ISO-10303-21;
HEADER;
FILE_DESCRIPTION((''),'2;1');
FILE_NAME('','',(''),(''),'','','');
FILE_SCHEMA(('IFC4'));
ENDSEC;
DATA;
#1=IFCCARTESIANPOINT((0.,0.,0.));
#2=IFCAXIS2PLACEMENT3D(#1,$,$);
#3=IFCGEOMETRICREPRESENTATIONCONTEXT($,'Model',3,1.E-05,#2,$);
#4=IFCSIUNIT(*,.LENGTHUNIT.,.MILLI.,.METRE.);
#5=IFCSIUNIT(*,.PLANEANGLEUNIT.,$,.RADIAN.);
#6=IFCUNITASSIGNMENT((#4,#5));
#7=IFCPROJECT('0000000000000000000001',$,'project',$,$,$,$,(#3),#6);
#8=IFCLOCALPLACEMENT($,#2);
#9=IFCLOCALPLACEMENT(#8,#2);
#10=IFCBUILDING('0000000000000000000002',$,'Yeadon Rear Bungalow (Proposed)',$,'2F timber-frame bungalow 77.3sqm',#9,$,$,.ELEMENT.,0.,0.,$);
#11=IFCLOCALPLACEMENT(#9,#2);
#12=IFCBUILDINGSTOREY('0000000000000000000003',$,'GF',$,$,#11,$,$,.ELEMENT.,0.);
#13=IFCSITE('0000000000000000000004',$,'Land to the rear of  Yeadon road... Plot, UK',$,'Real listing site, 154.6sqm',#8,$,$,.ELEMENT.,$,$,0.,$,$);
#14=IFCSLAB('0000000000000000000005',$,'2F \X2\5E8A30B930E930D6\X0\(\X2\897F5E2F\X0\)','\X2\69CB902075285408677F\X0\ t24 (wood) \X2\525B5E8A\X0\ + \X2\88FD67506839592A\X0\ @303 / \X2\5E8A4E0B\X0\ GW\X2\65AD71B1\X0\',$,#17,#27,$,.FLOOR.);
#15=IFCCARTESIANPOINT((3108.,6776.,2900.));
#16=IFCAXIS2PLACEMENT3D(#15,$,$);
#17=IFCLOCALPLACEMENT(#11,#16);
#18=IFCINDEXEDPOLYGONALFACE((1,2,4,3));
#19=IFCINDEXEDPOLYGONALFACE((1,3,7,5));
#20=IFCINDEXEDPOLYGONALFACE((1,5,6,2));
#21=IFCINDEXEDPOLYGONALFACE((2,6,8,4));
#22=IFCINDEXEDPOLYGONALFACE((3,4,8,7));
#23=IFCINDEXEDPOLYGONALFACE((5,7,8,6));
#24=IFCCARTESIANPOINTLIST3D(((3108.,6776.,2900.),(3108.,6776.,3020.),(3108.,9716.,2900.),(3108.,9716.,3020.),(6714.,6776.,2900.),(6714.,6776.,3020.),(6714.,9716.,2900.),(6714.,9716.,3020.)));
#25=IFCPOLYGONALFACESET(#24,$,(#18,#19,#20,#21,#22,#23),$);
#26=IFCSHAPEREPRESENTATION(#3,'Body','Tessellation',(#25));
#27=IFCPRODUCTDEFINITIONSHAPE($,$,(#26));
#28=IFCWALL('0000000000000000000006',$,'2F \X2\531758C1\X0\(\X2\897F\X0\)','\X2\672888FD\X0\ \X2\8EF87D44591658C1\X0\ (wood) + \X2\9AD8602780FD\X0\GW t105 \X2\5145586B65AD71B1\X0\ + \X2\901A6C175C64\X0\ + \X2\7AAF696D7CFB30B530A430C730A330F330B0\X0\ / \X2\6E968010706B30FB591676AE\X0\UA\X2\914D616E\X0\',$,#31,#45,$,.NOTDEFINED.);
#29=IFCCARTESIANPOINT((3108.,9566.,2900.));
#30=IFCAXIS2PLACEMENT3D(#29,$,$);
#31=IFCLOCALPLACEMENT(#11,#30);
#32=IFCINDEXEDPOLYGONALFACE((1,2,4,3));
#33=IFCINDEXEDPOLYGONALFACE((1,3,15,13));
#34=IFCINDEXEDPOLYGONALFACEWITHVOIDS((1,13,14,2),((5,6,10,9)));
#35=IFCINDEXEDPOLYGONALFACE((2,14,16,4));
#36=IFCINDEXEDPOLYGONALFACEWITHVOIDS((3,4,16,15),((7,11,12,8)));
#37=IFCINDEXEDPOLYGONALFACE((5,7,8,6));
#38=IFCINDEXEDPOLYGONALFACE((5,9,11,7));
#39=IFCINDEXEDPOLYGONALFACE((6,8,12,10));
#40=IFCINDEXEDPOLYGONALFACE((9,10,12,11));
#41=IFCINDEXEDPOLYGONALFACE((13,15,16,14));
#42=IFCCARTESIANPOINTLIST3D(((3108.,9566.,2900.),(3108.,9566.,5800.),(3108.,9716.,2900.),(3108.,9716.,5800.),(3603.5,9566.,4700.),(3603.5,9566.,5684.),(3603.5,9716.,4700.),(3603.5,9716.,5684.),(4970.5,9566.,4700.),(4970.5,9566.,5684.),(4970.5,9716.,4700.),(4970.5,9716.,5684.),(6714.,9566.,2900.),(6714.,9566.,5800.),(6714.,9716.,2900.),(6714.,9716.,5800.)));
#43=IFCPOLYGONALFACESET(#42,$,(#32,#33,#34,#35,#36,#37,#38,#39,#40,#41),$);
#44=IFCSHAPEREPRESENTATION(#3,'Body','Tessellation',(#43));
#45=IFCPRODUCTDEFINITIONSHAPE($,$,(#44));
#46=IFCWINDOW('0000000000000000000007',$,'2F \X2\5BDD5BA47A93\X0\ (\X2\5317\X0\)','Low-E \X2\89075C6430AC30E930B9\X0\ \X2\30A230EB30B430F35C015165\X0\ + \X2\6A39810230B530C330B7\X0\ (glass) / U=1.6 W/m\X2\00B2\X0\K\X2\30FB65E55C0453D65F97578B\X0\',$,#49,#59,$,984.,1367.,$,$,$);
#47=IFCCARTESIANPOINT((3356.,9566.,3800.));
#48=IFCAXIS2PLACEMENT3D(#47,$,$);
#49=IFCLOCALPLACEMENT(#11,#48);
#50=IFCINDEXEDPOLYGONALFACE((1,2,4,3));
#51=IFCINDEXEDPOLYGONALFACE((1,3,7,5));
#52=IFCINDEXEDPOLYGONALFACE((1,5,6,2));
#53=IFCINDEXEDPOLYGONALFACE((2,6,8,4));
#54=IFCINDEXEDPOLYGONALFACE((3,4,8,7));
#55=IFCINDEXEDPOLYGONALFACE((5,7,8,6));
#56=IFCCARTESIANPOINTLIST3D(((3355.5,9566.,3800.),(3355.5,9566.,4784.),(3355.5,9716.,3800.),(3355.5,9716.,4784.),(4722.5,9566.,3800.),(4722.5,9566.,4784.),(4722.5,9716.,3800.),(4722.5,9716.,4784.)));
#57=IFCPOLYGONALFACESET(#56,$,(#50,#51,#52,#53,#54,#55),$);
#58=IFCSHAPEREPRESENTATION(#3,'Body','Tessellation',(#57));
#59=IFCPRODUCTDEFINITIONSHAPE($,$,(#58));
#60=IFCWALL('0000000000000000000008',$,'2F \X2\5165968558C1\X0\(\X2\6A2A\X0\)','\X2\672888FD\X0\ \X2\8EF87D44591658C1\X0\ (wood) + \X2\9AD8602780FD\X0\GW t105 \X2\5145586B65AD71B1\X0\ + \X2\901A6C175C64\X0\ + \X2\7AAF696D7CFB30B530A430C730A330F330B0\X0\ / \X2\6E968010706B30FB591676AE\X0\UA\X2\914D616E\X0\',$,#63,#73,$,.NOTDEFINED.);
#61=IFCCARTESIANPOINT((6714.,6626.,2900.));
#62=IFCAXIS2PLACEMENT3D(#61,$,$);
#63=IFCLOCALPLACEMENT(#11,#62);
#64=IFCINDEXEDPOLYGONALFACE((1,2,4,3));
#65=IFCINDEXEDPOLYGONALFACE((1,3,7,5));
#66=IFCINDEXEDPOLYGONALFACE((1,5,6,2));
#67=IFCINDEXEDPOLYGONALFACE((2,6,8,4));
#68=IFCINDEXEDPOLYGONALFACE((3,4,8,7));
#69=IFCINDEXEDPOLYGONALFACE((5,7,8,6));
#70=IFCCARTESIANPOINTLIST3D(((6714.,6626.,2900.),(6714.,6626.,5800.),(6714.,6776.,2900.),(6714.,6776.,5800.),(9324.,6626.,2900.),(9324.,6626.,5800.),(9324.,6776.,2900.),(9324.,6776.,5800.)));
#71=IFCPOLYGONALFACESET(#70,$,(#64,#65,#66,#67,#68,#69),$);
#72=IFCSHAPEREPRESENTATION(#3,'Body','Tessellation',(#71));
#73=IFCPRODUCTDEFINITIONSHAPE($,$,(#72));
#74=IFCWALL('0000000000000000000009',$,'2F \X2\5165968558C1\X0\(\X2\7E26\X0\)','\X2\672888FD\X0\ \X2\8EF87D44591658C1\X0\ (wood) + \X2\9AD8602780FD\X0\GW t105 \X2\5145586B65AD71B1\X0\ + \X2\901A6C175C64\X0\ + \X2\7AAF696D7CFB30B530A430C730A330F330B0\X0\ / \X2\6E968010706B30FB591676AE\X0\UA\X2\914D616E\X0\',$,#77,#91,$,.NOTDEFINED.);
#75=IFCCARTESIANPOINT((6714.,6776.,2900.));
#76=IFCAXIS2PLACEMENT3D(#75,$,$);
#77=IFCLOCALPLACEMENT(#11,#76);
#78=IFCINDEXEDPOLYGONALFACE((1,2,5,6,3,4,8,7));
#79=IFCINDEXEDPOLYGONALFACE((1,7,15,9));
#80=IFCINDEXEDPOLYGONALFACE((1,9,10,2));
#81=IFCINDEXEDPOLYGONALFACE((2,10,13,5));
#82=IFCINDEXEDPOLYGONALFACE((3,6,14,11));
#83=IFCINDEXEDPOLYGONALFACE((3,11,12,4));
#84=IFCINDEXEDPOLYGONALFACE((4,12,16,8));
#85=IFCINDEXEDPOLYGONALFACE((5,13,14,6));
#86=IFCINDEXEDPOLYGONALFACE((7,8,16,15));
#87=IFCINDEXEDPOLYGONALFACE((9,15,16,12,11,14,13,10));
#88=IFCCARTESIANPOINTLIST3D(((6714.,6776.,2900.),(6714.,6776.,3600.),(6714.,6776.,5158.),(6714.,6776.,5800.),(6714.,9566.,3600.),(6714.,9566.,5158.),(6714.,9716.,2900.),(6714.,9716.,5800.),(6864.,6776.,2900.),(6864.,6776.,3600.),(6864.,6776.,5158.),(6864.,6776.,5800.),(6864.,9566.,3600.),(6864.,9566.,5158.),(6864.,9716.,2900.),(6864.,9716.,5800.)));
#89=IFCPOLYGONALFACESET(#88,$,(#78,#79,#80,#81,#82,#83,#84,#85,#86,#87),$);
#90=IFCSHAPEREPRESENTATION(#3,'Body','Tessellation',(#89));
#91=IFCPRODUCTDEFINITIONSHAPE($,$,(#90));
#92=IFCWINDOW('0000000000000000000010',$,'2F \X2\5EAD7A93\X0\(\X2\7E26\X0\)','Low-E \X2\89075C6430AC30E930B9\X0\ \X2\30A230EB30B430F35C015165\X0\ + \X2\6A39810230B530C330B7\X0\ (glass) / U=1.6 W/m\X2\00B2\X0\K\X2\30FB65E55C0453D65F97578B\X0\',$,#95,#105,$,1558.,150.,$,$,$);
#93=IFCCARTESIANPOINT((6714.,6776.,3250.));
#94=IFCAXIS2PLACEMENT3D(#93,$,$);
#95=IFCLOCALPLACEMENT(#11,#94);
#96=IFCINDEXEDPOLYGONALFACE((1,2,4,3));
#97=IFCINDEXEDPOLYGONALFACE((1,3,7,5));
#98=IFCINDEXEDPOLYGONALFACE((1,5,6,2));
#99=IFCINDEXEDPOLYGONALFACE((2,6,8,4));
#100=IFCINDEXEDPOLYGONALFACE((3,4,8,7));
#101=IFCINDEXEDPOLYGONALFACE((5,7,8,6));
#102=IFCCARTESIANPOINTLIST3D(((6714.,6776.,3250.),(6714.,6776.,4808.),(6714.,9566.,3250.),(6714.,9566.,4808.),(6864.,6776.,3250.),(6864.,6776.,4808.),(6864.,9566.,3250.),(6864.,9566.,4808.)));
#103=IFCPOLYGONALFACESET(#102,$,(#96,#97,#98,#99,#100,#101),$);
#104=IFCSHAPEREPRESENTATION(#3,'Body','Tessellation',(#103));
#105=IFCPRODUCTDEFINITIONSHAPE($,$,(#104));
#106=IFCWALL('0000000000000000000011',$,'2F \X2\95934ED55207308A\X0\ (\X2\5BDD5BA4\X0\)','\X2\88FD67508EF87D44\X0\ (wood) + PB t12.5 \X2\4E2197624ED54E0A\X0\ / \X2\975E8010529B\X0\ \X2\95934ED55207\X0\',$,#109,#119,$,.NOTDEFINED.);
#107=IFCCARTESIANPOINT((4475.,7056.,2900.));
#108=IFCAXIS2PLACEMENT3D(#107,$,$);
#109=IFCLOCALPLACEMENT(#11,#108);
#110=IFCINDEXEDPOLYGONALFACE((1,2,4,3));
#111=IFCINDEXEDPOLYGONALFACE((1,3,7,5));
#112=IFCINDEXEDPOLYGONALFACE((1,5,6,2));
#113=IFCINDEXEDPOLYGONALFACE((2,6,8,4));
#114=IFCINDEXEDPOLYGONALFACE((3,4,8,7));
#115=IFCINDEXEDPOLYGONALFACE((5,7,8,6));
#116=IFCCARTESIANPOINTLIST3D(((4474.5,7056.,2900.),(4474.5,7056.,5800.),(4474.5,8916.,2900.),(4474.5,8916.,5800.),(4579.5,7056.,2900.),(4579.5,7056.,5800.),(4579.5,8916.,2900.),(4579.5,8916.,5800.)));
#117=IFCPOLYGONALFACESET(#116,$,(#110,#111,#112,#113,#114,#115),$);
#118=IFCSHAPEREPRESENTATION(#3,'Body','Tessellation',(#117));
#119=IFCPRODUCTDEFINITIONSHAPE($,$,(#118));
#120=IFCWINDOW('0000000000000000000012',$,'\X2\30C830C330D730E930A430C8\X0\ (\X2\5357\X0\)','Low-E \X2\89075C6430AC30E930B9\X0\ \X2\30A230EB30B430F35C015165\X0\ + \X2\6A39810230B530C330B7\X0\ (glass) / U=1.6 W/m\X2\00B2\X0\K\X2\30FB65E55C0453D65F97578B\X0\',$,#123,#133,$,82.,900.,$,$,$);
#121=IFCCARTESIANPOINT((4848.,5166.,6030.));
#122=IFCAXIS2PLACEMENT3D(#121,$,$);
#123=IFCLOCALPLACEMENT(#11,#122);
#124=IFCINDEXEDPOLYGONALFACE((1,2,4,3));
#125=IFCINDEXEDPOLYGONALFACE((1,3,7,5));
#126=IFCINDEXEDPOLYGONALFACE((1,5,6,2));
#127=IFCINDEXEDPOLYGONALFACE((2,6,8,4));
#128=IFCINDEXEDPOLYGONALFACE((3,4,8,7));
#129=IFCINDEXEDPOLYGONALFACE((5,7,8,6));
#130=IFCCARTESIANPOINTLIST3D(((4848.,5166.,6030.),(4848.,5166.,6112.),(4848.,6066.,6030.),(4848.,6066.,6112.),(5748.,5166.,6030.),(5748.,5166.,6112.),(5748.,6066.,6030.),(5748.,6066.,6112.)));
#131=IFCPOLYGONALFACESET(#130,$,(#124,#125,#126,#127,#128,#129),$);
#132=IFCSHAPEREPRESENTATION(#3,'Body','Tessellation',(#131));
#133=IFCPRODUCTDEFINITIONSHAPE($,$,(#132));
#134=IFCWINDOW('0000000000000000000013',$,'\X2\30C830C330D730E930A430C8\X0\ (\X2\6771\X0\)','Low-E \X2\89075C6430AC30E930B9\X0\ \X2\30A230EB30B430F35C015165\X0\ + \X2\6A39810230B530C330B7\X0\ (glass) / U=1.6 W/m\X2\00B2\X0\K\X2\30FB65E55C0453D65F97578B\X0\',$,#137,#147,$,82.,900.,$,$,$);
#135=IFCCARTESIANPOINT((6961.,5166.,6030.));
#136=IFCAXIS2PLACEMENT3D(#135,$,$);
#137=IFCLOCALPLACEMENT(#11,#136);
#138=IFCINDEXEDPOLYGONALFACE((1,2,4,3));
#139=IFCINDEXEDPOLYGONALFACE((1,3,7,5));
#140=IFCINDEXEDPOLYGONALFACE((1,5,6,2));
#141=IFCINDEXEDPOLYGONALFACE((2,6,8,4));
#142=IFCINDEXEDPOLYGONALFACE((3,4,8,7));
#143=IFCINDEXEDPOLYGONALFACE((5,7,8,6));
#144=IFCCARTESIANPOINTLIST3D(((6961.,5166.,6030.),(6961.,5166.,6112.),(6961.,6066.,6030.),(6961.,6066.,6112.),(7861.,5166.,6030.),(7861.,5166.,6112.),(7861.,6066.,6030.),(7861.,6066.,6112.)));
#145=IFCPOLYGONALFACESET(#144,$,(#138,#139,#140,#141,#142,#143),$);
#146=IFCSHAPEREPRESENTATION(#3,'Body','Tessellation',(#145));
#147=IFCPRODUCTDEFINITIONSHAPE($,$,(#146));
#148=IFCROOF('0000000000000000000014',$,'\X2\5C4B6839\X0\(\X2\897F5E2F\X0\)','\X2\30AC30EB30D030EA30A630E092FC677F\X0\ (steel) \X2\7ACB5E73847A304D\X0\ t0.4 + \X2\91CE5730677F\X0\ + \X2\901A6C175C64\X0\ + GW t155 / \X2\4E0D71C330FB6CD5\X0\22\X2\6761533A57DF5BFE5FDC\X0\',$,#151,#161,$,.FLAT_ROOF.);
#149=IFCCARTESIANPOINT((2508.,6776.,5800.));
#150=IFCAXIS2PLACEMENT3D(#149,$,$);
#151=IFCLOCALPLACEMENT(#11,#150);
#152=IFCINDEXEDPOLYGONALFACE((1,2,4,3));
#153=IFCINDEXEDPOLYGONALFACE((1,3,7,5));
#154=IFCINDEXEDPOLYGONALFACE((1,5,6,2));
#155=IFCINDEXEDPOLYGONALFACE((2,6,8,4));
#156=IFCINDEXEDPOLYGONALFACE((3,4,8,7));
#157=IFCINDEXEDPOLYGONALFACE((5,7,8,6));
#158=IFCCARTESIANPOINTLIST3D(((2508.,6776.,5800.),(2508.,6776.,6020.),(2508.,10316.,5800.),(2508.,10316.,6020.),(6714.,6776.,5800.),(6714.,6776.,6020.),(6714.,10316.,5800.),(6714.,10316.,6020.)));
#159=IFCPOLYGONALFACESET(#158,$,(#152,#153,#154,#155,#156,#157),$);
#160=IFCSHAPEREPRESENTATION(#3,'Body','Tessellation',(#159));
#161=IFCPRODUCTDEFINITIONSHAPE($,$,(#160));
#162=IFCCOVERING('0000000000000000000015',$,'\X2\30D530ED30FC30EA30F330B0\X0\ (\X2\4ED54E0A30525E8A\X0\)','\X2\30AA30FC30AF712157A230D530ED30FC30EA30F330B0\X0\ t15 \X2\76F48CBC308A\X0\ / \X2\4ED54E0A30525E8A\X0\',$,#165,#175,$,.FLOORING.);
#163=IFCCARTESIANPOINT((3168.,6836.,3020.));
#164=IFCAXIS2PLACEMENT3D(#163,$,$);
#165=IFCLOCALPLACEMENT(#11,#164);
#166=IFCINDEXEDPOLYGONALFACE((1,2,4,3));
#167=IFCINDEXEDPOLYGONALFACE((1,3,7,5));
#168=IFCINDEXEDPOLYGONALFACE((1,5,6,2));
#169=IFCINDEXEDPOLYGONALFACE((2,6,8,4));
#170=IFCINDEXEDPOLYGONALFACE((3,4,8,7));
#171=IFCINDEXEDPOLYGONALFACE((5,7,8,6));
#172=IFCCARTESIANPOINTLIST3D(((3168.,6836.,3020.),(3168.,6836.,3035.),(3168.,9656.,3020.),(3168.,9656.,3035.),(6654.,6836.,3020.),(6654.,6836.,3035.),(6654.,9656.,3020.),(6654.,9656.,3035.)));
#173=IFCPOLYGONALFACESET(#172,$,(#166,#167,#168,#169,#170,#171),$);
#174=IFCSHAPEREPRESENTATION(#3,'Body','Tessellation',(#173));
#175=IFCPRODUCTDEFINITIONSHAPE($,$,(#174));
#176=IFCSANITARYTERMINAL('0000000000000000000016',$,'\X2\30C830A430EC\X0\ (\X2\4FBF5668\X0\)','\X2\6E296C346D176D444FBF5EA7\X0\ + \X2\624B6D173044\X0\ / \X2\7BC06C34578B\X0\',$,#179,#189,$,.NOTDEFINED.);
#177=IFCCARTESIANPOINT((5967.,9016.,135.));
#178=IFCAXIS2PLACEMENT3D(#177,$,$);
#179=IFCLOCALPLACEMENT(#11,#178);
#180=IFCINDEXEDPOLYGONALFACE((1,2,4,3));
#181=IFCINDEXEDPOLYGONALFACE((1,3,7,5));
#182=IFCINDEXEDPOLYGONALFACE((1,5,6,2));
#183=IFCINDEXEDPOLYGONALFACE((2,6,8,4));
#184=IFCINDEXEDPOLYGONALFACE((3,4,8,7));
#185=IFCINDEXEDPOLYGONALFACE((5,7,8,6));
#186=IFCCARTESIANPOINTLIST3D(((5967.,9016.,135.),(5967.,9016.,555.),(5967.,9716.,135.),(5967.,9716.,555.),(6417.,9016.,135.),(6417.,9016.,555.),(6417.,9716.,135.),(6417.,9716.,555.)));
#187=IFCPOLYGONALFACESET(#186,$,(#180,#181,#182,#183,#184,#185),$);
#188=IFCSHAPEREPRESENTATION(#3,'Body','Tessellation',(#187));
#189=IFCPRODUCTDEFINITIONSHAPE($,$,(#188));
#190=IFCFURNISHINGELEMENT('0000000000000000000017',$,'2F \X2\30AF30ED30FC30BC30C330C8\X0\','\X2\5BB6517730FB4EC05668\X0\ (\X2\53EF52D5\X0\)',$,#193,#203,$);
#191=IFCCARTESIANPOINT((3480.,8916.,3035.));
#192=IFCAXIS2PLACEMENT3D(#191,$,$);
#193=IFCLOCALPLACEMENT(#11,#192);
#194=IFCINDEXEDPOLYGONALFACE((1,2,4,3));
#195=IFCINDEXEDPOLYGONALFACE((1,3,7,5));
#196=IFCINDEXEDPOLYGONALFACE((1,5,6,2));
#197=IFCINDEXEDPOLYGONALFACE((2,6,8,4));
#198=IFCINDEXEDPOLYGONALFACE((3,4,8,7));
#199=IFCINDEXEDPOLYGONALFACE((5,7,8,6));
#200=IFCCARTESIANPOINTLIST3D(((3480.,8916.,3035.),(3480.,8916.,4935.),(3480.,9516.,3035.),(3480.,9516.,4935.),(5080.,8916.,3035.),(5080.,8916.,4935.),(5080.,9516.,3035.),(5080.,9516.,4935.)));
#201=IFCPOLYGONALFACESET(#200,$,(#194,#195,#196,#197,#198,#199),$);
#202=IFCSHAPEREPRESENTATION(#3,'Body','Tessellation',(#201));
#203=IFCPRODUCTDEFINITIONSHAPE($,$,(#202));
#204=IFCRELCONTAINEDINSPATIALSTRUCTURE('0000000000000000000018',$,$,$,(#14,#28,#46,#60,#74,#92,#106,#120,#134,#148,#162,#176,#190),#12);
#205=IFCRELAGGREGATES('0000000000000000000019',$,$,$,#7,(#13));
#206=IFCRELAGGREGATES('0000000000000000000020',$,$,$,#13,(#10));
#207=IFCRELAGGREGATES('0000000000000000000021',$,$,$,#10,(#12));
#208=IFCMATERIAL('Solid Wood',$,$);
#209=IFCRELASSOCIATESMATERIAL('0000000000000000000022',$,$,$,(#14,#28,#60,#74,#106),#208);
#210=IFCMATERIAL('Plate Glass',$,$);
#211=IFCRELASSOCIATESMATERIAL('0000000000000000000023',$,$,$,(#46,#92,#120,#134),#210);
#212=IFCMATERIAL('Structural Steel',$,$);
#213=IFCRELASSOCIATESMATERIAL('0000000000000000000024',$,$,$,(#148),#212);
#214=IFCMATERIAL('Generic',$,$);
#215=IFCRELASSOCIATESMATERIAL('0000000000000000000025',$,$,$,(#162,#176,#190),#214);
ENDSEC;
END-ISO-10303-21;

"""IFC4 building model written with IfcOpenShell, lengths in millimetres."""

from ifc_helpers import new_model, si_unit, frame, frame_2d, origin, place, context, project, spatial, rectangle, extrude, material, element, fill, save


model = new_model("IFC4")

# Units and contexts
model_context = context("Model", 3, precision=1e-05, world=origin())
ifc_project = project(units=[si_unit("LENGTHUNIT", "METRE", prefix="MILLI"), si_unit("PLANEANGLEUNIT", "RADIAN")], contexts=[model_context])

# Site, building, storey
site_placement = place(None, origin())
site = spatial("IfcSite", under=ifc_project, at=site_placement, Name="Land to the rear of  Yeadon road... Plot, UK", ObjectType="Real listing site, 154.6sqm", CompositionType="ELEMENT", RefElevation=0.0)
building_placement = place(site_placement, origin())
building = spatial("IfcBuilding", under=site, at=building_placement, Name="Yeadon Rear Bungalow (Proposed)", ObjectType="2F timber-frame bungalow 77.3sqm", CompositionType="ELEMENT", ElevationOfRefHeight=0.0, ElevationOfTerrain=0.0)
storey_placement = place(building_placement, origin())
storey = spatial("IfcBuildingStorey", under=building, at=storey_placement, Name="GF", CompositionType="ELEMENT", Elevation=0.0)

# Slab
ifc_material_1 = material(Name="Solid Wood")
slab_placement = place(storey_placement, frame((3108.0, 6776.0, 2900.0)))
element("IfcSlab", 1, at=slab_placement, inside=storey, material=ifc_material_1, Name="2F 床スラブ(西帯)", Description="構造用合板 t24 (wood) 剛床 + 製材根太 @303 / 床下 GW断熱", PredefinedType="FLOOR", context=model_context, shape_type="SweptSolid", body=[
    extrude(rectangle(XDim=3606.0, YDim=2940.0, at=frame_2d((1803.0, 1470.0))), frame((3108.0, 6776.0, 2900.0)), (0.0, 0.0, 1.0), 120.0),
])

# Wall, opening, window
wall_1_placement = place(storey_placement, frame((3108.0, 9566.0, 2900.0)))
wall_1 = element("IfcWall", 2, at=wall_1_placement, inside=storey, material=ifc_material_1, Name="2F 北壁(西)", Description="木製 軸組外壁 (wood) + 高性能GW t105 充填断熱 + 通気層 + 窯業系サイディング / 準耐火・外皮UA配慮", PredefinedType="NOTDEFINED", context=model_context, shape_type="SweptSolid", body=[
    extrude(rectangle(XDim=3606.0, YDim=150.0, at=frame_2d((1803.0, 75.0))), frame((3108.0, 9566.0, 2900.0)), (0.0, 0.0, 1.0), 2900.0),
])
opening_1_placement = place(storey_placement, frame((3356.0, 9566.0, 3800.0)))
opening_1 = element("IfcOpeningElement", 3, at=opening_1_placement, cuts=wall_1, PredefinedType="NOTDEFINED", context=model_context, shape_type="SweptSolid", body=[
    extrude(rectangle(XDim=1367.0, YDim=150.0, at=frame_2d((683.0, 75.0))), frame((3356.0, 9566.0, 3800.0)), (0.0, 0.0, 1.0), 984.0),
])
ifc_material_2 = material(Name="Plate Glass")
window_1_placement = place(storey_placement, frame((3356.0, 9566.0, 3800.0)))
window_1 = element("IfcWindow", 4, at=window_1_placement, inside=storey, material=ifc_material_2, Name="2F 寝室窓 (北)", Description="Low-E 複層ガラス アルゴン封入 + 樹脂サッシ (glass) / U=1.6 W/m²K・日射取得型", OverallHeight=984.0, OverallWidth=1367.0, context=model_context, shape_type="SweptSolid", body=[
    extrude(rectangle(XDim=1367.0, YDim=150.0, at=frame_2d((683.0, 75.0))), frame((3356.0, 9566.0, 3800.0)), (0.0, 0.0, 1.0), 984.0),
])
fill(opening_1, window_1)

# Wall
wall_2_placement = place(storey_placement, frame((6714.0, 6626.0, 2900.0)))
element("IfcWall", 5, at=wall_2_placement, inside=storey, material=ifc_material_1, Name="2F 入隅壁(横)", Description="木製 軸組外壁 (wood) + 高性能GW t105 充填断熱 + 通気層 + 窯業系サイディング / 準耐火・外皮UA配慮", PredefinedType="NOTDEFINED", context=model_context, shape_type="SweptSolid", body=[
    extrude(rectangle(XDim=2610.0, YDim=150.0, at=frame_2d((1305.0, 75.0))), frame((6714.0, 6626.0, 2900.0)), (0.0, 0.0, 1.0), 2900.0),
])

# Wall, opening, window
wall_3_placement = place(storey_placement, frame((6714.0, 6776.0, 2900.0)))
wall_3 = element("IfcWall", 6, at=wall_3_placement, inside=storey, material=ifc_material_1, Name="2F 入隅壁(縦)", Description="木製 軸組外壁 (wood) + 高性能GW t105 充填断熱 + 通気層 + 窯業系サイディング / 準耐火・外皮UA配慮", PredefinedType="NOTDEFINED", context=model_context, shape_type="SweptSolid", body=[
    extrude(rectangle(XDim=150.0, YDim=2940.0, at=frame_2d((75.0, 1470.0))), frame((6714.0, 6776.0, 2900.0)), (0.0, 0.0, 1.0), 2900.0),
])
opening_2_placement = place(storey_placement, frame((6714.0, 6776.0, 3250.0)))
opening_2 = element("IfcOpeningElement", 7, at=opening_2_placement, cuts=wall_3, PredefinedType="NOTDEFINED", context=model_context, shape_type="SweptSolid", body=[
    extrude(rectangle(XDim=150.0, YDim=2790.0, at=frame_2d((75.0, 1395.0))), frame((6714.0, 6776.0, 3250.0)), (0.0, 0.0, 1.0), 1558.0),
])
window_2_placement = place(storey_placement, frame((6714.0, 6776.0, 3250.0)))
window_2 = element("IfcWindow", 8, at=window_2_placement, inside=storey, material=ifc_material_2, Name="2F 庭窓(縦)", Description="Low-E 複層ガラス アルゴン封入 + 樹脂サッシ (glass) / U=1.6 W/m²K・日射取得型", OverallHeight=1558.0, OverallWidth=150.0, context=model_context, shape_type="SweptSolid", body=[
    extrude(rectangle(XDim=150.0, YDim=2790.0, at=frame_2d((75.0, 1395.0))), frame((6714.0, 6776.0, 3250.0)), (0.0, 0.0, 1.0), 1558.0),
])
fill(opening_2, window_2)

# Wall
wall_4_placement = place(storey_placement, frame((4475.0, 7056.0, 2900.0)))
element("IfcWall", 9, at=wall_4_placement, inside=storey, material=ifc_material_1, Name="2F 間仕切り (寝室)", Description="製材軸組 (wood) + PB t12.5 両面仕上 / 非耐力 間仕切", PredefinedType="NOTDEFINED", context=model_context, shape_type="SweptSolid", body=[
    extrude(rectangle(XDim=105.0, YDim=1860.0, at=frame_2d((52.0, 930.0))), frame((4475.0, 7056.0, 2900.0)), (0.0, 0.0, 1.0), 2900.0),
])

# Windows
window_3_placement = place(storey_placement, frame((4848.0, 5166.0, 6030.0)))
element("IfcWindow", 10, at=window_3_placement, inside=storey, material=ifc_material_2, Name="トップライト (南)", Description="Low-E 複層ガラス アルゴン封入 + 樹脂サッシ (glass) / U=1.6 W/m²K・日射取得型", OverallHeight=82.0, OverallWidth=900.0, context=model_context, shape_type="SweptSolid", body=[
    extrude(rectangle(XDim=900.0, YDim=900.0, at=frame_2d((450.0, 450.0))), frame((4848.0, 5166.0, 6030.0)), (0.0, 0.0, 1.0), 82.0),
])
window_4_placement = place(storey_placement, frame((6961.0, 5166.0, 6030.0)))
element("IfcWindow", 11, at=window_4_placement, inside=storey, material=ifc_material_2, Name="トップライト (東)", Description="Low-E 複層ガラス アルゴン封入 + 樹脂サッシ (glass) / U=1.6 W/m²K・日射取得型", OverallHeight=82.0, OverallWidth=900.0, context=model_context, shape_type="SweptSolid", body=[
    extrude(rectangle(XDim=900.0, YDim=900.0, at=frame_2d((450.0, 450.0))), frame((6961.0, 5166.0, 6030.0)), (0.0, 0.0, 1.0), 82.0),
])

# Roof
ifc_material_3 = material(Name="Structural Steel")
for number, where, name in (
    (12, (2508.0, 6776.0, 5800.0), "屋根(西帯)"),
):
    element("IfcRoof", number, at=place(storey_placement, frame(where)), inside=storey, material=ifc_material_3, Name=name, Description="ガルバリウム鋼板 (steel) 立平葺き t0.4 + 野地板 + 通気層 + GW t155 / 不燃・法22条区域対応", PredefinedType="FLAT_ROOF", context=model_context, shape_type="SweptSolid", body=[
        extrude(rectangle(XDim=4206.0, YDim=3540.0, at=frame_2d((2103.0, 1770.0))), frame((2508.0, 6776.0, 5800.0)), (0.0, 0.0, 1.0), 220.0),
    ])

# Covering
ifc_material_4 = material(Name="Generic")
covering_placement = place(storey_placement, frame((3168.0, 6836.0, 3020.0)))
element("IfcCovering", 13, at=covering_placement, inside=storey, material=ifc_material_4, Name="フローリング (仕上げ床)", Description="オーク無垢フローリング t15 直貼り / 仕上げ床", PredefinedType="FLOORING", context=model_context, shape_type="SweptSolid", body=[
    extrude(rectangle(XDim=3486.0, YDim=2820.0, at=frame_2d((1743.0, 1410.0))), frame((3168.0, 6836.0, 3020.0)), (0.0, 0.0, 1.0), 15.0),
])

# Sanitary terminal
sanitary_terminal_placement = place(storey_placement, frame((5967.0, 9016.0, 135.0)))
element("IfcSanitaryTerminal", 14, at=sanitary_terminal_placement, inside=storey, material=ifc_material_4, Name="トイレ (便器)", Description="温水洗浄便座 + 手洗い / 節水型", PredefinedType="NOTDEFINED", context=model_context, shape_type="SweptSolid", body=[
    extrude(rectangle(XDim=450.0, YDim=700.0, at=frame_2d((225.0, 350.0))), frame((5967.0, 9016.0, 135.0)), (0.0, 0.0, 1.0), 420.0),
])

# Furnishing element
furnishing_1_placement = place(storey_placement, frame((3480.0, 8916.0, 3035.0)))
element("IfcFurnishingElement", 15, at=furnishing_1_placement, inside=storey, material=ifc_material_4, Name="2F クローゼット", Description="家具・什器 (可動)", context=model_context, shape_type="SweptSolid", body=[
    extrude(rectangle(XDim=1600.0, YDim=600.0, at=frame_2d((800.0, 300.0))), frame((3480.0, 8916.0, 3035.0)), (0.0, 0.0, 1.0), 1900.0),
])

save(model, "model.ifc")
